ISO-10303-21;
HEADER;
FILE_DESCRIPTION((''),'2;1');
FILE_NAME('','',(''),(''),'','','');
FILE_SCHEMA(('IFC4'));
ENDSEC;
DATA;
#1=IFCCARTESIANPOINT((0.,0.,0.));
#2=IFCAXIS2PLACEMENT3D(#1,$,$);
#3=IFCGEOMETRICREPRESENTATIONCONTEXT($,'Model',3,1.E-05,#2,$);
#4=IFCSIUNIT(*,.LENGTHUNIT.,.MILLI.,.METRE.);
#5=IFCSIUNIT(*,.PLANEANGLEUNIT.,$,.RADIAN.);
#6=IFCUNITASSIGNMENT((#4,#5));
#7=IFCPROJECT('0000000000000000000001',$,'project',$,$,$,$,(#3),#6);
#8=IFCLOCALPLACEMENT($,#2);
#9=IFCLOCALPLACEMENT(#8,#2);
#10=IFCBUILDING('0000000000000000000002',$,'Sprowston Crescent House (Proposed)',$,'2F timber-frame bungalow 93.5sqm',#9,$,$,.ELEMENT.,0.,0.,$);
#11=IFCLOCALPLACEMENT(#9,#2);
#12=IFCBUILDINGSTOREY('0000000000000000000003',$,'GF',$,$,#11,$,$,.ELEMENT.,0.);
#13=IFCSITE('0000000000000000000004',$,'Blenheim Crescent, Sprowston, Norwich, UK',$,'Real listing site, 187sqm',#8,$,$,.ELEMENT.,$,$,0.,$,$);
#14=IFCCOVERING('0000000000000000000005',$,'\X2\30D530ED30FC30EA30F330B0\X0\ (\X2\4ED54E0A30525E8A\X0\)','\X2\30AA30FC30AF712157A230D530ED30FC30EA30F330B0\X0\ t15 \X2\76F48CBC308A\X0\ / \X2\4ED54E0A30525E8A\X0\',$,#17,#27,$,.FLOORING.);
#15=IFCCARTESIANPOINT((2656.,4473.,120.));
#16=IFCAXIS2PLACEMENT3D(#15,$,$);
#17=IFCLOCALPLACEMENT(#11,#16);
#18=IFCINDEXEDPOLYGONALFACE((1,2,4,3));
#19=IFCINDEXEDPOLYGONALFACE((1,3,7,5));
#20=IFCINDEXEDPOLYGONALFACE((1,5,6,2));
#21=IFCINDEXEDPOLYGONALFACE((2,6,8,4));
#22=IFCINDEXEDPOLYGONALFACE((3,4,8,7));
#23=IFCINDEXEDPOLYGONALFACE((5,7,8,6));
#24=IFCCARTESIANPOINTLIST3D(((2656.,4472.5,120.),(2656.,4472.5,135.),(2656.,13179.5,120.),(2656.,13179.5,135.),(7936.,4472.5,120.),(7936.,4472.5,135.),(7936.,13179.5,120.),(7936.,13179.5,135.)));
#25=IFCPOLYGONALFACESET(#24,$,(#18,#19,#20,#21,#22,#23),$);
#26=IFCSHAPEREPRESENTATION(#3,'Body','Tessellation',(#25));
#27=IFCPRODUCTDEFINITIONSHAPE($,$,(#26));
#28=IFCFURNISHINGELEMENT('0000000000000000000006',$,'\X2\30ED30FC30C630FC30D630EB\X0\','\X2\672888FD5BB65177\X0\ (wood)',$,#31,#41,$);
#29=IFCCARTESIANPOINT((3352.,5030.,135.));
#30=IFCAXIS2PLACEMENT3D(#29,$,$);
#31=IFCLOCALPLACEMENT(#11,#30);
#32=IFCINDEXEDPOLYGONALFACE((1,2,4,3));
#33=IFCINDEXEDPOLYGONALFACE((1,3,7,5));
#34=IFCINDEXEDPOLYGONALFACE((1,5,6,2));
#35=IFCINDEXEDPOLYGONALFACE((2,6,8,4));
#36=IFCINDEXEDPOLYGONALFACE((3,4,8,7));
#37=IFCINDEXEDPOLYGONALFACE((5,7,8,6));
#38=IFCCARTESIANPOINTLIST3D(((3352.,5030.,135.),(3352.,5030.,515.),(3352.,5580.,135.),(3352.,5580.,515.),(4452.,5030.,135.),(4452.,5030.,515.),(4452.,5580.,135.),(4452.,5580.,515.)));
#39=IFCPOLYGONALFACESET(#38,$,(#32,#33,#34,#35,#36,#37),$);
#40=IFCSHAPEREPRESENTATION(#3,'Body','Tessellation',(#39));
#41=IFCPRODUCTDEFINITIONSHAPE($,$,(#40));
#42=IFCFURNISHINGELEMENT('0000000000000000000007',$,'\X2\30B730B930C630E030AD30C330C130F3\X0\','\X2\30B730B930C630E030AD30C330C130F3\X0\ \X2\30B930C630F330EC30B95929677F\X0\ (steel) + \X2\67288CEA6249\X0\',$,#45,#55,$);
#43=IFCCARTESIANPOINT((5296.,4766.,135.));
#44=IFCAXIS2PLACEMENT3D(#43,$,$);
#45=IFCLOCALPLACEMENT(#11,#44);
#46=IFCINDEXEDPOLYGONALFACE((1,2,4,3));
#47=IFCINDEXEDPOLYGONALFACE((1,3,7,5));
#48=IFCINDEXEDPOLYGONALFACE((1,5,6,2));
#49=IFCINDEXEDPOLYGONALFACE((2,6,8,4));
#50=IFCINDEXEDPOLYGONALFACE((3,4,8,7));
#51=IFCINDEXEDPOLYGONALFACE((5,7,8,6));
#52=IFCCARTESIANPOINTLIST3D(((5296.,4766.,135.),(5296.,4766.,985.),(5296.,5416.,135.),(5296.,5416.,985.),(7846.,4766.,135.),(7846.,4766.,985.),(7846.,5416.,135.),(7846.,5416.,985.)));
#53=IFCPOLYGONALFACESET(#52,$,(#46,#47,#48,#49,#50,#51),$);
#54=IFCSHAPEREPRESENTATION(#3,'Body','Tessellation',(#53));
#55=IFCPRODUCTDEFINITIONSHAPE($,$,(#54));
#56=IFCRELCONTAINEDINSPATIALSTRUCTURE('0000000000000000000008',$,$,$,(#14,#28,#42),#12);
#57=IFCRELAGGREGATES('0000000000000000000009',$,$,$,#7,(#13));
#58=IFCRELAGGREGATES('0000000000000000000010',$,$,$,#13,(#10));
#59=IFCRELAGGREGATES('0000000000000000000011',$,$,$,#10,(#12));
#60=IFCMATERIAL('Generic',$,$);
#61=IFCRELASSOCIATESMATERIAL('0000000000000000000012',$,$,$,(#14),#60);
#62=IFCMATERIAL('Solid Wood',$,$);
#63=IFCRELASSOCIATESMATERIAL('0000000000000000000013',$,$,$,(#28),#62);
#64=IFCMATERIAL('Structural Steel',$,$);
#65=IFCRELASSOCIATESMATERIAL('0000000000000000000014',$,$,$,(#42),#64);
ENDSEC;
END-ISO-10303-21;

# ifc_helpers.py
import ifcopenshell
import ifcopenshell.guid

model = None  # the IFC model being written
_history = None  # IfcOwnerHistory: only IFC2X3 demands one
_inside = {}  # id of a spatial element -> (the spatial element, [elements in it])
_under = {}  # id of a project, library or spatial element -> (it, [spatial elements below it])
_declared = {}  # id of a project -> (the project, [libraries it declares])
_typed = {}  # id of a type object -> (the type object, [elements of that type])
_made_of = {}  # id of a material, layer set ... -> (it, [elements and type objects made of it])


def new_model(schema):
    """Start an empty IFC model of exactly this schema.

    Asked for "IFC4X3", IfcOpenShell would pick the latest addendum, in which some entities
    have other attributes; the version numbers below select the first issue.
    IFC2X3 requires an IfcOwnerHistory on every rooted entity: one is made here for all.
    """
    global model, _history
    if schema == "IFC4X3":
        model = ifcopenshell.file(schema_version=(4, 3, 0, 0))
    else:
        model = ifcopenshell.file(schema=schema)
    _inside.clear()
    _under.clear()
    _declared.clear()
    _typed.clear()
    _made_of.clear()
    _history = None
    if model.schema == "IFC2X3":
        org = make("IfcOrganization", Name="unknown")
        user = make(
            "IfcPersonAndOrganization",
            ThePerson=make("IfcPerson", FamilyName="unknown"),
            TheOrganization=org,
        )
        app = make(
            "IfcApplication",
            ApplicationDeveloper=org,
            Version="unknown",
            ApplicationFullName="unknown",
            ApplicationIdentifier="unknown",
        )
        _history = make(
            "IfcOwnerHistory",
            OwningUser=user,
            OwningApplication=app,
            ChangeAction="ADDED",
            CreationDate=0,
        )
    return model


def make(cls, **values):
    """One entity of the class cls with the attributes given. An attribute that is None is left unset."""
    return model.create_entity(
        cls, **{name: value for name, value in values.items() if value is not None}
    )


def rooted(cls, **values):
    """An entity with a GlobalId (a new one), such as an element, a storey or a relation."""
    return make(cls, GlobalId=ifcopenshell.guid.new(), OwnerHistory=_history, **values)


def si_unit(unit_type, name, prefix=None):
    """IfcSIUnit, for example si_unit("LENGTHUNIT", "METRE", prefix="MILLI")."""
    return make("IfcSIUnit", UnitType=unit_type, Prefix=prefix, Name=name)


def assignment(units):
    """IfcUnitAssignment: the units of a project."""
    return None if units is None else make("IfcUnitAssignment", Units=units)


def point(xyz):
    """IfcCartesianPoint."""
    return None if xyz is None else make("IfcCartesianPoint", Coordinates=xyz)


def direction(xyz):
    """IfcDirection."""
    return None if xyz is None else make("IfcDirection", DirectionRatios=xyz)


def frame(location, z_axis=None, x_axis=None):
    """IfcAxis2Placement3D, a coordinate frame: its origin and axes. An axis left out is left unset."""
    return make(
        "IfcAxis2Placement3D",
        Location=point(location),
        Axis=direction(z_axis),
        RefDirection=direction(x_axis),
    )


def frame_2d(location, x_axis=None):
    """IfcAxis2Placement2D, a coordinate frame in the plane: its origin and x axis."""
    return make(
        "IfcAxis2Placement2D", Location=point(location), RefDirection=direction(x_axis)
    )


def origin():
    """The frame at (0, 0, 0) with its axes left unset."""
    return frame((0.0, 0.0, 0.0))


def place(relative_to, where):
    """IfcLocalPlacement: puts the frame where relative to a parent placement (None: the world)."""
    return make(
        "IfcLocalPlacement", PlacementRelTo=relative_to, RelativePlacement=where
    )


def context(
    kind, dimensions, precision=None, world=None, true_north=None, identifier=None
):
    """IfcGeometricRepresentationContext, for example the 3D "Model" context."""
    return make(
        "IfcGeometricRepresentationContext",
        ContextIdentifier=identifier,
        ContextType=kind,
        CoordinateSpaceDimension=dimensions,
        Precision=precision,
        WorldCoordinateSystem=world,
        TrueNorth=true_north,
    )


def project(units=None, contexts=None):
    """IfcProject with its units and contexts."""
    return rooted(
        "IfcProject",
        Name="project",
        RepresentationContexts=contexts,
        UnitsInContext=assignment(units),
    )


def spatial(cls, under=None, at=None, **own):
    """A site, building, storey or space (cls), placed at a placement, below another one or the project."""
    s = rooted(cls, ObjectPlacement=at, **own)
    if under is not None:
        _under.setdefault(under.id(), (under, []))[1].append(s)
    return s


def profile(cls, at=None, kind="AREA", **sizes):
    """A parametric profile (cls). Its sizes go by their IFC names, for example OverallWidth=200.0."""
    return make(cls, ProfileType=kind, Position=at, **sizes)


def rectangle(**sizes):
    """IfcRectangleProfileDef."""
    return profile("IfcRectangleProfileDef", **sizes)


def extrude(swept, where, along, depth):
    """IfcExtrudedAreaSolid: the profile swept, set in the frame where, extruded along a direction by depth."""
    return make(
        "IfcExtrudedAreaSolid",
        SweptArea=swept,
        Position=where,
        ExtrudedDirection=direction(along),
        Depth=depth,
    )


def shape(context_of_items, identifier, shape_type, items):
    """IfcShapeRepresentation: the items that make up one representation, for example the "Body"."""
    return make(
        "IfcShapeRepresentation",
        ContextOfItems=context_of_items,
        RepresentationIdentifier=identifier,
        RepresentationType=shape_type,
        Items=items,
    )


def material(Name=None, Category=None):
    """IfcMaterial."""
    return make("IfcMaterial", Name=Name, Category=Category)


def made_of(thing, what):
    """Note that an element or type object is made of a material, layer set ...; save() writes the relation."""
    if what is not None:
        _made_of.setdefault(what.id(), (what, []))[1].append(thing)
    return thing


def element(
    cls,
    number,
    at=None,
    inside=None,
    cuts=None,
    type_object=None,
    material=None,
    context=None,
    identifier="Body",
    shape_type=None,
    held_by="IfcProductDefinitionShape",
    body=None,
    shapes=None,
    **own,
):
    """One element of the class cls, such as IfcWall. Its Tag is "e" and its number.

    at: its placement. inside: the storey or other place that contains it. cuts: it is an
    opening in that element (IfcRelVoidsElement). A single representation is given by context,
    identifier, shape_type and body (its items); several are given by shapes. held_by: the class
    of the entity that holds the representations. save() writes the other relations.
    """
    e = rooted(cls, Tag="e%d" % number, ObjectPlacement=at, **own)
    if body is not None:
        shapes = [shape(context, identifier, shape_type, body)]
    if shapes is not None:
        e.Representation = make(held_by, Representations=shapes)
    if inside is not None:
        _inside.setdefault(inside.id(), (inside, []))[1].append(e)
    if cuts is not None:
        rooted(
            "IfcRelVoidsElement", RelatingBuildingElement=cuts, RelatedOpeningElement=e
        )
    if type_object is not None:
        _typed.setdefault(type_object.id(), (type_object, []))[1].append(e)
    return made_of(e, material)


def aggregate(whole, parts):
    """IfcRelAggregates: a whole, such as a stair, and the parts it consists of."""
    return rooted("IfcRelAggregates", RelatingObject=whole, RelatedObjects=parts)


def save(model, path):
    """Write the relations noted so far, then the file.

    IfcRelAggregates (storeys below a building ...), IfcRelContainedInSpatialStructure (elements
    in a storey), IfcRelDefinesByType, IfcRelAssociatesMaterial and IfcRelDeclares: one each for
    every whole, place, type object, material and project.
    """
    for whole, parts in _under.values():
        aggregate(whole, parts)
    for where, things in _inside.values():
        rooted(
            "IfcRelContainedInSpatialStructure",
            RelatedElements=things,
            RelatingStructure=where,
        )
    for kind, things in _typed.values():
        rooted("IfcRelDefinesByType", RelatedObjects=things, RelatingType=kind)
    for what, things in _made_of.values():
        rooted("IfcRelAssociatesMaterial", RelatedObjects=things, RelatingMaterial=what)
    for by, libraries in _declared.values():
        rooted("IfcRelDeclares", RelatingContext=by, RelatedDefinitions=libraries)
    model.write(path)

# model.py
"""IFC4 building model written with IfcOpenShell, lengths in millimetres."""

from ifc_helpers import new_model, si_unit, frame, frame_2d, origin, place, context, project, spatial, rectangle, extrude, material, element, save


model = new_model("IFC4")

# Units and contexts
model_context = context("Model", 3, precision=1e-05, world=origin())
ifc_project = project(units=[si_unit("LENGTHUNIT", "METRE", prefix="MILLI"), si_unit("PLANEANGLEUNIT", "RADIAN")], contexts=[model_context])

# Site, building, storey
site_placement = place(None, origin())
site = spatial("IfcSite", under=ifc_project, at=site_placement, Name="Blenheim Crescent, Sprowston, Norwich, UK", ObjectType="Real listing site, 187sqm", CompositionType="ELEMENT", RefElevation=0.0)
building_placement = place(site_placement, origin())
building = spatial("IfcBuilding", under=site, at=building_placement, Name="Sprowston Crescent House (Proposed)", ObjectType="2F timber-frame bungalow 93.5sqm", CompositionType="ELEMENT", ElevationOfRefHeight=0.0, ElevationOfTerrain=0.0)
storey_placement = place(building_placement, origin())
storey = spatial("IfcBuildingStorey", under=building, at=storey_placement, Name="GF", CompositionType="ELEMENT", Elevation=0.0)

# Shared definitions
ifc_material_1 = material(Name="Solid Wood")

# Covering
ifc_material_2 = material(Name="Generic")
covering_placement = place(storey_placement, frame((2656.0, 4473.0, 120.0)))
element("IfcCovering", 1, at=covering_placement, inside=storey, material=ifc_material_2, Name="フローリング (仕上げ床)", Description="オーク無垢フローリング t15 直貼り / 仕上げ床", PredefinedType="FLOORING", context=model_context, shape_type="SweptSolid", body=[
    extrude(rectangle(XDim=5280.0, YDim=8707.0, at=frame_2d((2640.0, 4353.0))), frame((2656.0, 4473.0, 120.0)), (0.0, 0.0, 1.0), 15.0),
])

# Furnishing elements
furnishing_1_placement = place(storey_placement, frame((3352.0, 5030.0, 135.0)))
element("IfcFurnishingElement", 2, at=furnishing_1_placement, inside=storey, material=ifc_material_1, Name="ローテーブル", Description="木製家具 (wood)", context=model_context, shape_type="SweptSolid", body=[
    extrude(rectangle(XDim=1100.0, YDim=550.0, at=frame_2d((550.0, 275.0))), frame((3352.0, 5030.0, 135.0)), (0.0, 0.0, 1.0), 380.0),
])
ifc_material_3 = material(Name="Structural Steel")
furnishing_2_placement = place(storey_placement, frame((5296.0, 4766.0, 135.0)))
element("IfcFurnishingElement", 3, at=furnishing_2_placement, inside=storey, material=ifc_material_3, Name="システムキッチン", Description="システムキッチン ステンレス天板 (steel) + 木質扉", context=model_context, shape_type="SweptSolid", body=[
    extrude(rectangle(XDim=2550.0, YDim=650.0, at=frame_2d((1275.0, 325.0))), frame((5296.0, 4766.0, 135.0)), (0.0, 0.0, 1.0), 850.0),
])

save(model, "model.ifc")
